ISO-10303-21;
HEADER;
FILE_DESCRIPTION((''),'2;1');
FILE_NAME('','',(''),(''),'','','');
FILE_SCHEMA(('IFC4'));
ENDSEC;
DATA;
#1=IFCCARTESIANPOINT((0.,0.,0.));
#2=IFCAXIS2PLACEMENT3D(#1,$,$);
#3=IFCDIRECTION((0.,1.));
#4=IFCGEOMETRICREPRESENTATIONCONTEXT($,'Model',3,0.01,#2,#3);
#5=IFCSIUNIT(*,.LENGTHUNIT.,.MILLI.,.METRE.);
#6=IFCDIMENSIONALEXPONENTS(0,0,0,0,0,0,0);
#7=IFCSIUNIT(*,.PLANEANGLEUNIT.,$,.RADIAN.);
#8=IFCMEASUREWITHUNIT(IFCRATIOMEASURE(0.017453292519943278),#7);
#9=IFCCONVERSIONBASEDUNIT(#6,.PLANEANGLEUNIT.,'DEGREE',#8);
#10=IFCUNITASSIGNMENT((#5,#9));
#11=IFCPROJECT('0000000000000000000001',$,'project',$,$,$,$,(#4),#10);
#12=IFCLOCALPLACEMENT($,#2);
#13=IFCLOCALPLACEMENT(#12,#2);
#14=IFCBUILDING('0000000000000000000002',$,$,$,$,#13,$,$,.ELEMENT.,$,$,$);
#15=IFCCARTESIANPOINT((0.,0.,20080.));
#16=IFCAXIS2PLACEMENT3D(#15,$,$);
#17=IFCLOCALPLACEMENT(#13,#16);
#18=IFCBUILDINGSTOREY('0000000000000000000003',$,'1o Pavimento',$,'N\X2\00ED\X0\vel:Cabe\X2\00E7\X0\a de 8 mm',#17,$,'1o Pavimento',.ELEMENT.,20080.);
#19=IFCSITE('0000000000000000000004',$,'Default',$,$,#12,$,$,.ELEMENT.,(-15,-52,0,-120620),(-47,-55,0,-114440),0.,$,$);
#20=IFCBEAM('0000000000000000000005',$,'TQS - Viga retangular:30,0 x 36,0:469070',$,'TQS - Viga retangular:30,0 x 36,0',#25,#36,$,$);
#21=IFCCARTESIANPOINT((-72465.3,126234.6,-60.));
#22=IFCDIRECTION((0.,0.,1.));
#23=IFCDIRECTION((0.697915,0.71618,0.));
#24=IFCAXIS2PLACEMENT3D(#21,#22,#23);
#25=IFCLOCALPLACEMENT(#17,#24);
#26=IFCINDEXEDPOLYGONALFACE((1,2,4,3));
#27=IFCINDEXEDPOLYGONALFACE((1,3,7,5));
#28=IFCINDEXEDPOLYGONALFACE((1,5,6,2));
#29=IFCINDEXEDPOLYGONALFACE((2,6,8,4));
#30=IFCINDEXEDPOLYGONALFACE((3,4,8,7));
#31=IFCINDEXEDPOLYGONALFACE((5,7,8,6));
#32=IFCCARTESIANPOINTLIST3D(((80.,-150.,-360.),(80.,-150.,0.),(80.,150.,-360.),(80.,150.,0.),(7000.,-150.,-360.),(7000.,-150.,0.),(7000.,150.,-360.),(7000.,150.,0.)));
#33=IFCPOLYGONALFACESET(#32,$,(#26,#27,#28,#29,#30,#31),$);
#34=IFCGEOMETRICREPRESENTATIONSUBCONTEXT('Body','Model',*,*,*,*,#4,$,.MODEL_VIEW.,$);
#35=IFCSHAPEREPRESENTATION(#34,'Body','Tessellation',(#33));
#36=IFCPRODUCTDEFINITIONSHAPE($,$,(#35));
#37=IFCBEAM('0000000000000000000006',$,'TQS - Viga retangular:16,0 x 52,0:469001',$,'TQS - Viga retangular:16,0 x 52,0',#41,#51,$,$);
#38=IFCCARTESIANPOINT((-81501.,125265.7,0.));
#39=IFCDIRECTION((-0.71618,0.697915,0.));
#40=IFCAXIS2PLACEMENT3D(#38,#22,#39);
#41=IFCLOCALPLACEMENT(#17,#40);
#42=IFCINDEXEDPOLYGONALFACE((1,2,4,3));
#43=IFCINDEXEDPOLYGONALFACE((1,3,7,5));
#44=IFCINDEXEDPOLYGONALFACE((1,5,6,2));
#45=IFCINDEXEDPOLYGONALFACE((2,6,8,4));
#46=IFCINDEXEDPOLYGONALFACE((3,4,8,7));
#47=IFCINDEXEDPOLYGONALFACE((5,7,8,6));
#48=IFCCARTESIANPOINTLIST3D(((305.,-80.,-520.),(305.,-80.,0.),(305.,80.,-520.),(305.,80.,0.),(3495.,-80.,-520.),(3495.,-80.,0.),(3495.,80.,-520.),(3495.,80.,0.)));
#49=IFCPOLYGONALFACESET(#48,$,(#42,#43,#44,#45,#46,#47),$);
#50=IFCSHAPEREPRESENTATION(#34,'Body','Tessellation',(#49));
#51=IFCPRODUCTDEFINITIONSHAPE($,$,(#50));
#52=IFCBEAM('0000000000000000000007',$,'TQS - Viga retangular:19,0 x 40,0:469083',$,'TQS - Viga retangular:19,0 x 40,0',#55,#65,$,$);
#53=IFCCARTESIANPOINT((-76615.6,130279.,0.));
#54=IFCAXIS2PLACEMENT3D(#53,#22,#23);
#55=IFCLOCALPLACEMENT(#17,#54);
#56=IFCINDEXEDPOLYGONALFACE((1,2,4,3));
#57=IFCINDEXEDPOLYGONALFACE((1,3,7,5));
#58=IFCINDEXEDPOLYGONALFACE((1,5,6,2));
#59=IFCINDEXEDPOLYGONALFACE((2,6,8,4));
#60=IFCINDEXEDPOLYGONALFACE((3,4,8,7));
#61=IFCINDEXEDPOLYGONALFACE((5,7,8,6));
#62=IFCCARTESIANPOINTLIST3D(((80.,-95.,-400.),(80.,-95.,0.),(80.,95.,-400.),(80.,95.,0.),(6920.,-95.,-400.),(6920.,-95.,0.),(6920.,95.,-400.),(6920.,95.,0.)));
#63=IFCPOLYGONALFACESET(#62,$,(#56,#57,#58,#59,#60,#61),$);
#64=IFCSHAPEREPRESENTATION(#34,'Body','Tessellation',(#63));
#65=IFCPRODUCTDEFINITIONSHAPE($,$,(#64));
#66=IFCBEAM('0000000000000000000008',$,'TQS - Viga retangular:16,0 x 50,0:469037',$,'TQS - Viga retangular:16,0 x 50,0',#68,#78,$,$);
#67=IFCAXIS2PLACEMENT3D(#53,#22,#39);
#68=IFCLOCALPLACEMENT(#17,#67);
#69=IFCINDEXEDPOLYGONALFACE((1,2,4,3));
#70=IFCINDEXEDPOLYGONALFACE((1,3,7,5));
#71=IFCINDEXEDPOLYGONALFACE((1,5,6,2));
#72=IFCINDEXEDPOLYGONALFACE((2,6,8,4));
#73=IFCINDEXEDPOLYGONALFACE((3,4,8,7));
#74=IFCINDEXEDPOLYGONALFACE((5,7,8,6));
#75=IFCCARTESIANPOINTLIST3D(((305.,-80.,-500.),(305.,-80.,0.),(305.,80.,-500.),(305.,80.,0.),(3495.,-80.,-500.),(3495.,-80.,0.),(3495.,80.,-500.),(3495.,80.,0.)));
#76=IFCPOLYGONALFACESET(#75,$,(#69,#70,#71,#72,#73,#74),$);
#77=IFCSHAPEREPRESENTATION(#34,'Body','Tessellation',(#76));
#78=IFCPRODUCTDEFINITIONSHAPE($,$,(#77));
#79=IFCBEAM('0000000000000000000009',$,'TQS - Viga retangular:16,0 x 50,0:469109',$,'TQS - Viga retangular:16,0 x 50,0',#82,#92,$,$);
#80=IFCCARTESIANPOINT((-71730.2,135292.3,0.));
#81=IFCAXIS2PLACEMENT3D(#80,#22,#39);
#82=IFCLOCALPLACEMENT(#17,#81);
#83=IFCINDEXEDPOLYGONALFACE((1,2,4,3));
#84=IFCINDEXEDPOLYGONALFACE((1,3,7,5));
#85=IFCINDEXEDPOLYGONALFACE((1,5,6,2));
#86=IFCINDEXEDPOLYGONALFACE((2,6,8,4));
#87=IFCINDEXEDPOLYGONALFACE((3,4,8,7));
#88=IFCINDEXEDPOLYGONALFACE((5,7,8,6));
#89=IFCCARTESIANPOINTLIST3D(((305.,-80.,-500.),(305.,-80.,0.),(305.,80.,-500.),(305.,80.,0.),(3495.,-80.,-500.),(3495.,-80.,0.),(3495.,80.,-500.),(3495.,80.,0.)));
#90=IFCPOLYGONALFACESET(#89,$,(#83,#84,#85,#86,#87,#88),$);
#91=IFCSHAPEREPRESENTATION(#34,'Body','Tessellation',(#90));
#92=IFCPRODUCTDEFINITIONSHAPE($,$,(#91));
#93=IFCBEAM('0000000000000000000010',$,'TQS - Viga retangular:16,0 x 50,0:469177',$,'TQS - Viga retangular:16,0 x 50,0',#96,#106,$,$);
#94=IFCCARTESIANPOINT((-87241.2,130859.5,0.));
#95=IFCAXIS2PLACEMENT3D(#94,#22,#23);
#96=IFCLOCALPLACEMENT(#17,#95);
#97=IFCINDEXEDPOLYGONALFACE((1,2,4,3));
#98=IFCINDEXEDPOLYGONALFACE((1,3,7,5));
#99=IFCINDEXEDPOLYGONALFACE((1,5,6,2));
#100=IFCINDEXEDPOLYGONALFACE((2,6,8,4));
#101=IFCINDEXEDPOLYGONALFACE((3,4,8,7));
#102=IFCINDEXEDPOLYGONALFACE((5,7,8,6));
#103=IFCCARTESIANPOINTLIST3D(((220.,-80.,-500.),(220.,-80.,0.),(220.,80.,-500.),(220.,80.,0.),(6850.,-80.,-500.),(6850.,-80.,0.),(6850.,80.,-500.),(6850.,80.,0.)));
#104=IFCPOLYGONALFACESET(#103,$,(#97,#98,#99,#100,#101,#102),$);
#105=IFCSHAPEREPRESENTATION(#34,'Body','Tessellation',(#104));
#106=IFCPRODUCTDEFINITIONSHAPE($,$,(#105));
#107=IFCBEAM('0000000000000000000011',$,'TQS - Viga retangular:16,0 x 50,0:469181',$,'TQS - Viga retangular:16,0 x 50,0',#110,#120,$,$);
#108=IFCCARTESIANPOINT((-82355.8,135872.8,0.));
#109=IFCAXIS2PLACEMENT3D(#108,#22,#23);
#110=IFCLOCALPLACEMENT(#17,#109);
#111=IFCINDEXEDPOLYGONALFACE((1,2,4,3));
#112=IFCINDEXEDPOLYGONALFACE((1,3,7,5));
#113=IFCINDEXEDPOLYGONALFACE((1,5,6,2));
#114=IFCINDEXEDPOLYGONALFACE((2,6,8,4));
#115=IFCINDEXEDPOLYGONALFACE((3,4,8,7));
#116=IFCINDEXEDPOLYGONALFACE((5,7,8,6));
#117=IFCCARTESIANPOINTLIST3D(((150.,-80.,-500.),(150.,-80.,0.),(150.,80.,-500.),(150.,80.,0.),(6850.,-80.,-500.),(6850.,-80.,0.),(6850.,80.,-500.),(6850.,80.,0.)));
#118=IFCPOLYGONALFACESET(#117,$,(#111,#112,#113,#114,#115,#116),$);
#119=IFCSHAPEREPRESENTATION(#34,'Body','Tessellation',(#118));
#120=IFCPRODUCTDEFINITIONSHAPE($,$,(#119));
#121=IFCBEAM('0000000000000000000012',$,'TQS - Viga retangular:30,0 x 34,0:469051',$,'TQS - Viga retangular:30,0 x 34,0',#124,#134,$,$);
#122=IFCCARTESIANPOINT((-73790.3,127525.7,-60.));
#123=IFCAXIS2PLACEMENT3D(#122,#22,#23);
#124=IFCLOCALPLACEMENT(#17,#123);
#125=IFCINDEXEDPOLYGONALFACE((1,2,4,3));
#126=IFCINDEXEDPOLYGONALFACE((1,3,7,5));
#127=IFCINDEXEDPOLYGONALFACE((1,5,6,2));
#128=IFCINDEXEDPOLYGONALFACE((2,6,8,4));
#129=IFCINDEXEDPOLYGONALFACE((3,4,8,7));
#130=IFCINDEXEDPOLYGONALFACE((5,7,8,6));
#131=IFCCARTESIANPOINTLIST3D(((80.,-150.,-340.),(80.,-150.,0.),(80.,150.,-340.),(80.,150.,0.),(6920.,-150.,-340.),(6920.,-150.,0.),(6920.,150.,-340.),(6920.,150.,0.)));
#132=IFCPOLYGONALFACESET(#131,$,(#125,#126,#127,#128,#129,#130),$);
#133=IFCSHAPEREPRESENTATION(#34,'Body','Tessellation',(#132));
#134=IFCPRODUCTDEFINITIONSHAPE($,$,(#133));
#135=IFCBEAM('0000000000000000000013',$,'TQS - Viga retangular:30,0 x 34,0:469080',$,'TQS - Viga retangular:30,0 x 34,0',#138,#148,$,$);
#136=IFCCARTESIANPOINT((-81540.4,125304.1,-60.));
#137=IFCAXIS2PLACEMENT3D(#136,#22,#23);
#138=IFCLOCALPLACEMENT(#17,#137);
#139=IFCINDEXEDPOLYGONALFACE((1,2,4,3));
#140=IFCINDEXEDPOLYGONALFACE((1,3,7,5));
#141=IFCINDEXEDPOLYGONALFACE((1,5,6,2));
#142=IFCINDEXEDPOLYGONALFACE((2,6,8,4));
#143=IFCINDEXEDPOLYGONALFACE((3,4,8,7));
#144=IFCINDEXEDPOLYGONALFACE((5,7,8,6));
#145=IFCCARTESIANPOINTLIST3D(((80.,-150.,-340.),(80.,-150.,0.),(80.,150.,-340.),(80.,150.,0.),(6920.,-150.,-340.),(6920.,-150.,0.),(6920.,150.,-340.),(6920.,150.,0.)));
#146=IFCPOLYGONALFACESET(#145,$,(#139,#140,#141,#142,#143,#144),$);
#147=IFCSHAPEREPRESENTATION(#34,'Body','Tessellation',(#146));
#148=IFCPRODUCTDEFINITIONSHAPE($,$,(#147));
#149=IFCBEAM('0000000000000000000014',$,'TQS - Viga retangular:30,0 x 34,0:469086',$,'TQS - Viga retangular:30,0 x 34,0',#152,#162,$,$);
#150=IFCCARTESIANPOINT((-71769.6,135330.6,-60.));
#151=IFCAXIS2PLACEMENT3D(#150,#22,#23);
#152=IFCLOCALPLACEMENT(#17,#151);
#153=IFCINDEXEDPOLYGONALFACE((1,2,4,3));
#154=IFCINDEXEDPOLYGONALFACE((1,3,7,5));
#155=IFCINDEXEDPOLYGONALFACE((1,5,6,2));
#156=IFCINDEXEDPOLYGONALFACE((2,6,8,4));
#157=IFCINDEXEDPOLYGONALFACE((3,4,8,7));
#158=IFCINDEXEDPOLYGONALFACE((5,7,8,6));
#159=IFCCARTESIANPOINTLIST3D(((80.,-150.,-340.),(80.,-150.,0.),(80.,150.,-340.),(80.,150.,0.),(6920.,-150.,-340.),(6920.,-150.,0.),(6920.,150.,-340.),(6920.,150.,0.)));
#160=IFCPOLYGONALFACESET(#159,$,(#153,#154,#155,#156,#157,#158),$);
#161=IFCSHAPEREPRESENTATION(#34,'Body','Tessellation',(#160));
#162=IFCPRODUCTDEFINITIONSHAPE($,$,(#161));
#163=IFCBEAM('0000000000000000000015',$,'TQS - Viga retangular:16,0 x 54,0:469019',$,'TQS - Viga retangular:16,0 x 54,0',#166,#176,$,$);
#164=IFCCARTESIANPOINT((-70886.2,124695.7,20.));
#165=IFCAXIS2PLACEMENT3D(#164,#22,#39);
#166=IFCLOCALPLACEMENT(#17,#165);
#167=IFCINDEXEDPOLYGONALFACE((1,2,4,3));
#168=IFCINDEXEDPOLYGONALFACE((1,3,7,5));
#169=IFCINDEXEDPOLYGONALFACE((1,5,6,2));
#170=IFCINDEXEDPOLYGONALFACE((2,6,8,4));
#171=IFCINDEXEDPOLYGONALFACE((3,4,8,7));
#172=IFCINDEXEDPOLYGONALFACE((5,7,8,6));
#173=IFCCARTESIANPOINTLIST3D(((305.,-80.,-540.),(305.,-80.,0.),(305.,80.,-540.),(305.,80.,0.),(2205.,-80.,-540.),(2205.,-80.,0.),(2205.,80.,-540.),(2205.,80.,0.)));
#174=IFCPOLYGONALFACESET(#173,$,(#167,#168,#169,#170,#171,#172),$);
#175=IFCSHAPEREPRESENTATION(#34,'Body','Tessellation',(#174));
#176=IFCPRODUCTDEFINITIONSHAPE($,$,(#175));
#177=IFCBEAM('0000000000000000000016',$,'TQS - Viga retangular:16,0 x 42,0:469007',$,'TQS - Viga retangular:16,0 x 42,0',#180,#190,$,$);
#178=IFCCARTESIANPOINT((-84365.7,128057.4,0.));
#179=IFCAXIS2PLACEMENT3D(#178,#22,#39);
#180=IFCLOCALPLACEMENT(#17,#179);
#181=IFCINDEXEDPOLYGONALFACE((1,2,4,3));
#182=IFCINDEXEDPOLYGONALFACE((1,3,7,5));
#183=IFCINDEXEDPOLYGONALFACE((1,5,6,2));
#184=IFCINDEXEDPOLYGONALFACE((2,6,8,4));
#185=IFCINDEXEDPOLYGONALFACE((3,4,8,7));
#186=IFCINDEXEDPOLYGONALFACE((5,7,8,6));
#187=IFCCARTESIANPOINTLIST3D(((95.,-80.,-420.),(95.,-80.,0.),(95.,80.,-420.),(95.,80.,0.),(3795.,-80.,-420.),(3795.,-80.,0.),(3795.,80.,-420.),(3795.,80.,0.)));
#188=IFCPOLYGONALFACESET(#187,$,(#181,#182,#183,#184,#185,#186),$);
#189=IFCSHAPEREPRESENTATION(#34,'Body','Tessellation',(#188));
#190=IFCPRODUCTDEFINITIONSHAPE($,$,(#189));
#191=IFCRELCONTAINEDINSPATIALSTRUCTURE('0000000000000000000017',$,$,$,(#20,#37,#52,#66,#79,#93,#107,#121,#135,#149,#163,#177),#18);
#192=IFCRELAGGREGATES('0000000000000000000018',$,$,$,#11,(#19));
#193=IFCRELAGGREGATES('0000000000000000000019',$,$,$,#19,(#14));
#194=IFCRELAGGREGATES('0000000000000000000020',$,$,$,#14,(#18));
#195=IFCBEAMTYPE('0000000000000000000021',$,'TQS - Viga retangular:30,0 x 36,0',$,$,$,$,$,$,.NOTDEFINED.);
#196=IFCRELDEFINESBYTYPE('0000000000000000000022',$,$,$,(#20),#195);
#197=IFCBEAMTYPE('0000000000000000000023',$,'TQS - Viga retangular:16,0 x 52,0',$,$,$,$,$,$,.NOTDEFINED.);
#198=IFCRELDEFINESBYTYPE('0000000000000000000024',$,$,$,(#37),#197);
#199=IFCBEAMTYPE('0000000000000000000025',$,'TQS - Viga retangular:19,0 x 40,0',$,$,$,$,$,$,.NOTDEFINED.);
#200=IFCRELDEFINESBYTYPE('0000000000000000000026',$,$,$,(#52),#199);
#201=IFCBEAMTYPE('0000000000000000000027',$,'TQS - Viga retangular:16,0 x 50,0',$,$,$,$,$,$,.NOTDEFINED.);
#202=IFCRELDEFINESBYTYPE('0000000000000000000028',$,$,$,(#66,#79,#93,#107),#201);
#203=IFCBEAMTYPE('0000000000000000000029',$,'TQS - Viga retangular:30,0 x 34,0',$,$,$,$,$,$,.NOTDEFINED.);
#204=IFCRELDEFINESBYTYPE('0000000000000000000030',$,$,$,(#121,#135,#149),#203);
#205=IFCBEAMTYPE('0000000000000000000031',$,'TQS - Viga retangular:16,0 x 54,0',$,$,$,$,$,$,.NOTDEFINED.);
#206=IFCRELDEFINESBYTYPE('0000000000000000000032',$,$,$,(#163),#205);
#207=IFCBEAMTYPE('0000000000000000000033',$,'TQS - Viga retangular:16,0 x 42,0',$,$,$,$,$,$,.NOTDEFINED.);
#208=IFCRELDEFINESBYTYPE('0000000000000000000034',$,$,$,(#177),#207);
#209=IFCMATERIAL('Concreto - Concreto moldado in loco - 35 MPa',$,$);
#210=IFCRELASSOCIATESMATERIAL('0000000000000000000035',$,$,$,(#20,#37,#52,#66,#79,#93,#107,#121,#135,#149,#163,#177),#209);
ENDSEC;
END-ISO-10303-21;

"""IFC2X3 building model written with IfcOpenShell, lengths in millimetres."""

from ifc_helpers import new_model, entity, si_unit, converted_unit, direction, frame, frame_2d, origin, origin_2d_with_axis, place, context, subcontext, project, spatial, rectangle, extrude, material, type_object, element, save


model = new_model("IFC2X3")

# Units and contexts
model_context = context("Model", 3, precision=0.01, world=origin(), true_north=direction((0.0, 1.0)))
body_context = subcontext(model_context, "Body", "Model", "MODEL_VIEW")
ifc_project = project(units=[si_unit("LENGTHUNIT", "METRE", prefix="MILLI"), converted_unit("PLANEANGLEUNIT", "DEGREE", entity("IfcRatioMeasure", 0.017453292519943278), si_unit("PLANEANGLEUNIT", "RADIAN"), dimensions=[0, 0, 0, 0, 0, 0, 0])], contexts=[model_context])

# Site, building, storey
site_placement = place(None, origin())
site = spatial("IfcSite", under=ifc_project, at=site_placement, Name="Default", CompositionType="ELEMENT", RefLatitude=(-15, -52, 0, -120620), RefLongitude=(-47, -55, 0, -114440), RefElevation=0.0)
building_placement = place(site_placement, origin())
building = spatial("IfcBuilding", under=site, at=building_placement, CompositionType="ELEMENT")
storey_placement = place(building_placement, frame((0.0, 0.0, 20080.0)))
storey = spatial("IfcBuildingStorey", under=building, at=storey_placement, Name="1o Pavimento", ObjectType="Nível:Cabeça de 8 mm", LongName="1o Pavimento", CompositionType="ELEMENT", Elevation=20080.0)

# Beams
ifc_material_1 = material(Name="Concreto - Concreto moldado in loco - 35 MPa")
beam_type_1 = type_object("IfcBeamType", Name="TQS - Viga retangular:30,0 x 36,0", PredefinedType="NOTDEFINED")
beam_1_placement = place(storey_placement, frame((-72465.3, 126234.6, -60.0), z_axis=(0.0, 0.0, 1.0), x_axis=(0.697915, 0.71618, 0.0)))
element("IfcBeam", 1, at=beam_1_placement, inside=storey, type_object=beam_type_1, material=ifc_material_1, Name="TQS - Viga retangular:30,0 x 36,0:469070", ObjectType="TQS - Viga retangular:30,0 x 36,0", context=body_context, shape_type="SweptSolid", body=[
    extrude(rectangle(XDim=360.0, YDim=300.0, at=frame_2d((0.0, 0.0), x_axis=(1.0, 0.0))), frame((80.0, 0.0, -180.0), z_axis=(1.0, 0.0, 0.0), x_axis=(0.0, 0.0, -1.0)), (0.0, 0.0, 1.0), 6920.0),
])
beam_type_2 = type_object("IfcBeamType", Name="TQS - Viga retangular:16,0 x 52,0", PredefinedType="NOTDEFINED")
beam_2_placement = place(storey_placement, frame((-81501.0, 125265.7, 0.0), z_axis=(0.0, 0.0, 1.0), x_axis=(-0.71618, 0.697915, 0.0)))
element("IfcBeam", 2, at=beam_2_placement, inside=storey, type_object=beam_type_2, material=ifc_material_1, Name="TQS - Viga retangular:16,0 x 52,0:469001", ObjectType="TQS - Viga retangular:16,0 x 52,0", context=body_context, shape_type="SweptSolid", body=[
    extrude(rectangle(XDim=520.0, YDim=160.0, at=frame_2d((0.0, 0.0), x_axis=(1.0, 0.0))), frame((305.0, 0.0, -260.0), z_axis=(1.0, 0.0, 0.0), x_axis=(0.0, 0.0, -1.0)), (0.0, 0.0, 1.0), 3190.0),
])
beam_type_3 = type_object("IfcBeamType", Name="TQS - Viga retangular:19,0 x 40,0", PredefinedType="NOTDEFINED")
beam_3_placement = place(storey_placement, frame((-76615.6, 130279.0, 0.0), z_axis=(0.0, 0.0, 1.0), x_axis=(0.697915, 0.71618, 0.0)))
element("IfcBeam", 3, at=beam_3_placement, inside=storey, type_object=beam_type_3, material=ifc_material_1, Name="TQS - Viga retangular:19,0 x 40,0:469083", ObjectType="TQS - Viga retangular:19,0 x 40,0", context=body_context, shape_type="SweptSolid", body=[
    extrude(rectangle(XDim=400.0, YDim=190.0, at=frame_2d((0.0, 0.0), x_axis=(1.0, 0.0))), frame((80.0, 0.0, -200.0), z_axis=(1.0, 0.0, 0.0), x_axis=(0.0, 0.0, -1.0)), (0.0, 0.0, 1.0), 6840.0),
])
beam_type_4 = type_object("IfcBeamType", Name="TQS - Viga retangular:16,0 x 50,0", PredefinedType="NOTDEFINED")
beam_4_placement = place(storey_placement, frame((-76615.6, 130279.0, 0.0), z_axis=(0.0, 0.0, 1.0), x_axis=(-0.71618, 0.697915, 0.0)))
element("IfcBeam", 4, at=beam_4_placement, inside=storey, type_object=beam_type_4, material=ifc_material_1, Name="TQS - Viga retangular:16,0 x 50,0:469037", ObjectType="TQS - Viga retangular:16,0 x 50,0", context=body_context, shape_type="SweptSolid", body=[
    extrude(rectangle(XDim=500.0, YDim=160.0, at=frame_2d((0.0, 0.0), x_axis=(1.0, 0.0))), frame((305.0, 0.0, -250.0), z_axis=(1.0, 0.0, 0.0), x_axis=(0.0, 0.0, -1.0)), (0.0, 0.0, 1.0), 3190.0),
])
beam_5_placement = place(storey_placement, frame((-71730.2, 135292.3, 0.0), z_axis=(0.0, 0.0, 1.0), x_axis=(-0.71618, 0.697915, 0.0)))
element("IfcBeam", 5, at=beam_5_placement, inside=storey, type_object=beam_type_4, material=ifc_material_1, Name="TQS - Viga retangular:16,0 x 50,0:469109", ObjectType="TQS - Viga retangular:16,0 x 50,0", context=body_context, shape_type="SweptSolid", body=[
    extrude(rectangle(XDim=500.0, YDim=160.0, at=frame_2d((0.0, 0.0), x_axis=(1.0, 0.0))), frame((305.0, 0.0, -250.0), z_axis=(1.0, 0.0, 0.0), x_axis=(0.0, 0.0, -1.0)), (0.0, 0.0, 1.0), 3190.0),
])
beam_6_placement = place(storey_placement, frame((-87241.2, 130859.5, 0.0), z_axis=(0.0, 0.0, 1.0), x_axis=(0.697915, 0.71618, 0.0)))
element("IfcBeam", 6, at=beam_6_placement, inside=storey, type_object=beam_type_4, material=ifc_material_1, Name="TQS - Viga retangular:16,0 x 50,0:469177", ObjectType="TQS - Viga retangular:16,0 x 50,0", context=body_context, shape_type="SweptSolid", body=[
    extrude(rectangle(XDim=500.0, YDim=160.0, at=frame_2d((0.0, 0.0), x_axis=(1.0, 0.0))), frame((220.0, 0.0, -250.0), z_axis=(1.0, 0.0, 0.0), x_axis=(0.0, 0.0, -1.0)), (0.0, 0.0, 1.0), 6630.0),
])
beam_7_placement = place(storey_placement, frame((-82355.8, 135872.8, 0.0), z_axis=(0.0, 0.0, 1.0), x_axis=(0.697915, 0.71618, 0.0)))
element("IfcBeam", 7, at=beam_7_placement, inside=storey, type_object=beam_type_4, material=ifc_material_1, Name="TQS - Viga retangular:16,0 x 50,0:469181", ObjectType="TQS - Viga retangular:16,0 x 50,0", context=body_context, shape_type="SweptSolid", body=[
    extrude(rectangle(XDim=500.0, YDim=160.0, at=frame_2d((0.0, 0.0), x_axis=(1.0, 0.0))), frame((150.0, 0.0, -250.0), z_axis=(1.0, 0.0, 0.0), x_axis=(0.0, 0.0, -1.0)), (0.0, 0.0, 1.0), 6700.0),
])
beam_type_5 = type_object("IfcBeamType", Name="TQS - Viga retangular:30,0 x 34,0", PredefinedType="NOTDEFINED")
beam_8_placement = place(storey_placement, frame((-73790.3, 127525.7, -60.0), z_axis=(0.0, 0.0, 1.0), x_axis=(0.697915, 0.71618, 0.0)))
element("IfcBeam", 8, at=beam_8_placement, inside=storey, type_object=beam_type_5, material=ifc_material_1, Name="TQS - Viga retangular:30,0 x 34,0:469051", ObjectType="TQS - Viga retangular:30,0 x 34,0", context=body_context, shape_type="SweptSolid", body=[
    extrude(rectangle(XDim=340.0, YDim=300.0, at=frame_2d((0.0, 0.0), x_axis=(1.0, 0.0))), frame((80.0, 0.0, -170.0), z_axis=(1.0, 0.0, 0.0), x_axis=(0.0, 0.0, -1.0)), (0.0, 0.0, 1.0), 6840.0),
])
beam_9_placement = place(storey_placement, frame((-81540.4, 125304.1, -60.0), z_axis=(0.0, 0.0, 1.0), x_axis=(0.697915, 0.71618, 0.0)))
element("IfcBeam", 9, at=beam_9_placement, inside=storey, type_object=beam_type_5, material=ifc_material_1, Name="TQS - Viga retangular:30,0 x 34,0:469080", ObjectType="TQS - Viga retangular:30,0 x 34,0", context=body_context, shape_type="SweptSolid", body=[
    extrude(rectangle(XDim=340.0, YDim=300.0, at=origin_2d_with_axis()), frame((80.0, 0.0, -170.0), z_axis=(1.0, 0.0, 0.0), x_axis=(0.0, 0.0, -1.0)), (0.0, 0.0, 1.0), 6840.0),
])
beam_10_placement = place(storey_placement, frame((-71769.6, 135330.6, -60.0), z_axis=(0.0, 0.0, 1.0), x_axis=(0.697915, 0.71618, 0.0)))
element("IfcBeam", 10, at=beam_10_placement, inside=storey, type_object=beam_type_5, material=ifc_material_1, Name="TQS - Viga retangular:30,0 x 34,0:469086", ObjectType="TQS - Viga retangular:30,0 x 34,0", context=body_context, shape_type="SweptSolid", body=[
    extrude(rectangle(XDim=340.0, YDim=300.0, at=frame_2d((0.0, 0.0), x_axis=(1.0, 0.0))), frame((80.0, 0.0, -170.0), z_axis=(1.0, 0.0, 0.0), x_axis=(0.0, 0.0, -1.0)), (0.0, 0.0, 1.0), 6840.0),
])
beam_type_6 = type_object("IfcBeamType", Name="TQS - Viga retangular:16,0 x 54,0", PredefinedType="NOTDEFINED")
beam_11_placement = place(storey_placement, frame((-70886.2, 124695.7, 20.0), z_axis=(0.0, 0.0, 1.0), x_axis=(-0.71618, 0.697915, 0.0)))
element("IfcBeam", 11, at=beam_11_placement, inside=storey, type_object=beam_type_6, material=ifc_material_1, Name="TQS - Viga retangular:16,0 x 54,0:469019", ObjectType="TQS - Viga retangular:16,0 x 54,0", context=body_context, shape_type="SweptSolid", body=[
    extrude(rectangle(XDim=540.0, YDim=160.0, at=frame_2d((0.0, 0.0), x_axis=(1.0, 0.0))), frame((305.0, 0.0, -270.0), z_axis=(1.0, 0.0, 0.0), x_axis=(0.0, 0.0, -1.0)), (0.0, 0.0, 1.0), 1900.0),
])
beam_type_7 = type_object("IfcBeamType", Name="TQS - Viga retangular:16,0 x 42,0", PredefinedType="NOTDEFINED")
beam_12_placement = place(storey_placement, frame((-84365.7, 128057.4, 0.0), z_axis=(0.0, 0.0, 1.0), x_axis=(-0.71618, 0.697915, 0.0)))
element("IfcBeam", 12, at=beam_12_placement, inside=storey, type_object=beam_type_7, material=ifc_material_1, Name="TQS - Viga retangular:16,0 x 42,0:469007", ObjectType="TQS - Viga retangular:16,0 x 42,0", context=body_context, shape_type="SweptSolid", body=[
    extrude(rectangle(XDim=420.0, YDim=160.0, at=frame_2d((0.0, 0.0), x_axis=(1.0, 0.0))), frame((95.0, 0.0, -210.0), z_axis=(1.0, 0.0, 0.0), x_axis=(0.0, 0.0, -1.0)), (0.0, 0.0, 1.0), 3700.0),
])

save(model, "model.ifc")
